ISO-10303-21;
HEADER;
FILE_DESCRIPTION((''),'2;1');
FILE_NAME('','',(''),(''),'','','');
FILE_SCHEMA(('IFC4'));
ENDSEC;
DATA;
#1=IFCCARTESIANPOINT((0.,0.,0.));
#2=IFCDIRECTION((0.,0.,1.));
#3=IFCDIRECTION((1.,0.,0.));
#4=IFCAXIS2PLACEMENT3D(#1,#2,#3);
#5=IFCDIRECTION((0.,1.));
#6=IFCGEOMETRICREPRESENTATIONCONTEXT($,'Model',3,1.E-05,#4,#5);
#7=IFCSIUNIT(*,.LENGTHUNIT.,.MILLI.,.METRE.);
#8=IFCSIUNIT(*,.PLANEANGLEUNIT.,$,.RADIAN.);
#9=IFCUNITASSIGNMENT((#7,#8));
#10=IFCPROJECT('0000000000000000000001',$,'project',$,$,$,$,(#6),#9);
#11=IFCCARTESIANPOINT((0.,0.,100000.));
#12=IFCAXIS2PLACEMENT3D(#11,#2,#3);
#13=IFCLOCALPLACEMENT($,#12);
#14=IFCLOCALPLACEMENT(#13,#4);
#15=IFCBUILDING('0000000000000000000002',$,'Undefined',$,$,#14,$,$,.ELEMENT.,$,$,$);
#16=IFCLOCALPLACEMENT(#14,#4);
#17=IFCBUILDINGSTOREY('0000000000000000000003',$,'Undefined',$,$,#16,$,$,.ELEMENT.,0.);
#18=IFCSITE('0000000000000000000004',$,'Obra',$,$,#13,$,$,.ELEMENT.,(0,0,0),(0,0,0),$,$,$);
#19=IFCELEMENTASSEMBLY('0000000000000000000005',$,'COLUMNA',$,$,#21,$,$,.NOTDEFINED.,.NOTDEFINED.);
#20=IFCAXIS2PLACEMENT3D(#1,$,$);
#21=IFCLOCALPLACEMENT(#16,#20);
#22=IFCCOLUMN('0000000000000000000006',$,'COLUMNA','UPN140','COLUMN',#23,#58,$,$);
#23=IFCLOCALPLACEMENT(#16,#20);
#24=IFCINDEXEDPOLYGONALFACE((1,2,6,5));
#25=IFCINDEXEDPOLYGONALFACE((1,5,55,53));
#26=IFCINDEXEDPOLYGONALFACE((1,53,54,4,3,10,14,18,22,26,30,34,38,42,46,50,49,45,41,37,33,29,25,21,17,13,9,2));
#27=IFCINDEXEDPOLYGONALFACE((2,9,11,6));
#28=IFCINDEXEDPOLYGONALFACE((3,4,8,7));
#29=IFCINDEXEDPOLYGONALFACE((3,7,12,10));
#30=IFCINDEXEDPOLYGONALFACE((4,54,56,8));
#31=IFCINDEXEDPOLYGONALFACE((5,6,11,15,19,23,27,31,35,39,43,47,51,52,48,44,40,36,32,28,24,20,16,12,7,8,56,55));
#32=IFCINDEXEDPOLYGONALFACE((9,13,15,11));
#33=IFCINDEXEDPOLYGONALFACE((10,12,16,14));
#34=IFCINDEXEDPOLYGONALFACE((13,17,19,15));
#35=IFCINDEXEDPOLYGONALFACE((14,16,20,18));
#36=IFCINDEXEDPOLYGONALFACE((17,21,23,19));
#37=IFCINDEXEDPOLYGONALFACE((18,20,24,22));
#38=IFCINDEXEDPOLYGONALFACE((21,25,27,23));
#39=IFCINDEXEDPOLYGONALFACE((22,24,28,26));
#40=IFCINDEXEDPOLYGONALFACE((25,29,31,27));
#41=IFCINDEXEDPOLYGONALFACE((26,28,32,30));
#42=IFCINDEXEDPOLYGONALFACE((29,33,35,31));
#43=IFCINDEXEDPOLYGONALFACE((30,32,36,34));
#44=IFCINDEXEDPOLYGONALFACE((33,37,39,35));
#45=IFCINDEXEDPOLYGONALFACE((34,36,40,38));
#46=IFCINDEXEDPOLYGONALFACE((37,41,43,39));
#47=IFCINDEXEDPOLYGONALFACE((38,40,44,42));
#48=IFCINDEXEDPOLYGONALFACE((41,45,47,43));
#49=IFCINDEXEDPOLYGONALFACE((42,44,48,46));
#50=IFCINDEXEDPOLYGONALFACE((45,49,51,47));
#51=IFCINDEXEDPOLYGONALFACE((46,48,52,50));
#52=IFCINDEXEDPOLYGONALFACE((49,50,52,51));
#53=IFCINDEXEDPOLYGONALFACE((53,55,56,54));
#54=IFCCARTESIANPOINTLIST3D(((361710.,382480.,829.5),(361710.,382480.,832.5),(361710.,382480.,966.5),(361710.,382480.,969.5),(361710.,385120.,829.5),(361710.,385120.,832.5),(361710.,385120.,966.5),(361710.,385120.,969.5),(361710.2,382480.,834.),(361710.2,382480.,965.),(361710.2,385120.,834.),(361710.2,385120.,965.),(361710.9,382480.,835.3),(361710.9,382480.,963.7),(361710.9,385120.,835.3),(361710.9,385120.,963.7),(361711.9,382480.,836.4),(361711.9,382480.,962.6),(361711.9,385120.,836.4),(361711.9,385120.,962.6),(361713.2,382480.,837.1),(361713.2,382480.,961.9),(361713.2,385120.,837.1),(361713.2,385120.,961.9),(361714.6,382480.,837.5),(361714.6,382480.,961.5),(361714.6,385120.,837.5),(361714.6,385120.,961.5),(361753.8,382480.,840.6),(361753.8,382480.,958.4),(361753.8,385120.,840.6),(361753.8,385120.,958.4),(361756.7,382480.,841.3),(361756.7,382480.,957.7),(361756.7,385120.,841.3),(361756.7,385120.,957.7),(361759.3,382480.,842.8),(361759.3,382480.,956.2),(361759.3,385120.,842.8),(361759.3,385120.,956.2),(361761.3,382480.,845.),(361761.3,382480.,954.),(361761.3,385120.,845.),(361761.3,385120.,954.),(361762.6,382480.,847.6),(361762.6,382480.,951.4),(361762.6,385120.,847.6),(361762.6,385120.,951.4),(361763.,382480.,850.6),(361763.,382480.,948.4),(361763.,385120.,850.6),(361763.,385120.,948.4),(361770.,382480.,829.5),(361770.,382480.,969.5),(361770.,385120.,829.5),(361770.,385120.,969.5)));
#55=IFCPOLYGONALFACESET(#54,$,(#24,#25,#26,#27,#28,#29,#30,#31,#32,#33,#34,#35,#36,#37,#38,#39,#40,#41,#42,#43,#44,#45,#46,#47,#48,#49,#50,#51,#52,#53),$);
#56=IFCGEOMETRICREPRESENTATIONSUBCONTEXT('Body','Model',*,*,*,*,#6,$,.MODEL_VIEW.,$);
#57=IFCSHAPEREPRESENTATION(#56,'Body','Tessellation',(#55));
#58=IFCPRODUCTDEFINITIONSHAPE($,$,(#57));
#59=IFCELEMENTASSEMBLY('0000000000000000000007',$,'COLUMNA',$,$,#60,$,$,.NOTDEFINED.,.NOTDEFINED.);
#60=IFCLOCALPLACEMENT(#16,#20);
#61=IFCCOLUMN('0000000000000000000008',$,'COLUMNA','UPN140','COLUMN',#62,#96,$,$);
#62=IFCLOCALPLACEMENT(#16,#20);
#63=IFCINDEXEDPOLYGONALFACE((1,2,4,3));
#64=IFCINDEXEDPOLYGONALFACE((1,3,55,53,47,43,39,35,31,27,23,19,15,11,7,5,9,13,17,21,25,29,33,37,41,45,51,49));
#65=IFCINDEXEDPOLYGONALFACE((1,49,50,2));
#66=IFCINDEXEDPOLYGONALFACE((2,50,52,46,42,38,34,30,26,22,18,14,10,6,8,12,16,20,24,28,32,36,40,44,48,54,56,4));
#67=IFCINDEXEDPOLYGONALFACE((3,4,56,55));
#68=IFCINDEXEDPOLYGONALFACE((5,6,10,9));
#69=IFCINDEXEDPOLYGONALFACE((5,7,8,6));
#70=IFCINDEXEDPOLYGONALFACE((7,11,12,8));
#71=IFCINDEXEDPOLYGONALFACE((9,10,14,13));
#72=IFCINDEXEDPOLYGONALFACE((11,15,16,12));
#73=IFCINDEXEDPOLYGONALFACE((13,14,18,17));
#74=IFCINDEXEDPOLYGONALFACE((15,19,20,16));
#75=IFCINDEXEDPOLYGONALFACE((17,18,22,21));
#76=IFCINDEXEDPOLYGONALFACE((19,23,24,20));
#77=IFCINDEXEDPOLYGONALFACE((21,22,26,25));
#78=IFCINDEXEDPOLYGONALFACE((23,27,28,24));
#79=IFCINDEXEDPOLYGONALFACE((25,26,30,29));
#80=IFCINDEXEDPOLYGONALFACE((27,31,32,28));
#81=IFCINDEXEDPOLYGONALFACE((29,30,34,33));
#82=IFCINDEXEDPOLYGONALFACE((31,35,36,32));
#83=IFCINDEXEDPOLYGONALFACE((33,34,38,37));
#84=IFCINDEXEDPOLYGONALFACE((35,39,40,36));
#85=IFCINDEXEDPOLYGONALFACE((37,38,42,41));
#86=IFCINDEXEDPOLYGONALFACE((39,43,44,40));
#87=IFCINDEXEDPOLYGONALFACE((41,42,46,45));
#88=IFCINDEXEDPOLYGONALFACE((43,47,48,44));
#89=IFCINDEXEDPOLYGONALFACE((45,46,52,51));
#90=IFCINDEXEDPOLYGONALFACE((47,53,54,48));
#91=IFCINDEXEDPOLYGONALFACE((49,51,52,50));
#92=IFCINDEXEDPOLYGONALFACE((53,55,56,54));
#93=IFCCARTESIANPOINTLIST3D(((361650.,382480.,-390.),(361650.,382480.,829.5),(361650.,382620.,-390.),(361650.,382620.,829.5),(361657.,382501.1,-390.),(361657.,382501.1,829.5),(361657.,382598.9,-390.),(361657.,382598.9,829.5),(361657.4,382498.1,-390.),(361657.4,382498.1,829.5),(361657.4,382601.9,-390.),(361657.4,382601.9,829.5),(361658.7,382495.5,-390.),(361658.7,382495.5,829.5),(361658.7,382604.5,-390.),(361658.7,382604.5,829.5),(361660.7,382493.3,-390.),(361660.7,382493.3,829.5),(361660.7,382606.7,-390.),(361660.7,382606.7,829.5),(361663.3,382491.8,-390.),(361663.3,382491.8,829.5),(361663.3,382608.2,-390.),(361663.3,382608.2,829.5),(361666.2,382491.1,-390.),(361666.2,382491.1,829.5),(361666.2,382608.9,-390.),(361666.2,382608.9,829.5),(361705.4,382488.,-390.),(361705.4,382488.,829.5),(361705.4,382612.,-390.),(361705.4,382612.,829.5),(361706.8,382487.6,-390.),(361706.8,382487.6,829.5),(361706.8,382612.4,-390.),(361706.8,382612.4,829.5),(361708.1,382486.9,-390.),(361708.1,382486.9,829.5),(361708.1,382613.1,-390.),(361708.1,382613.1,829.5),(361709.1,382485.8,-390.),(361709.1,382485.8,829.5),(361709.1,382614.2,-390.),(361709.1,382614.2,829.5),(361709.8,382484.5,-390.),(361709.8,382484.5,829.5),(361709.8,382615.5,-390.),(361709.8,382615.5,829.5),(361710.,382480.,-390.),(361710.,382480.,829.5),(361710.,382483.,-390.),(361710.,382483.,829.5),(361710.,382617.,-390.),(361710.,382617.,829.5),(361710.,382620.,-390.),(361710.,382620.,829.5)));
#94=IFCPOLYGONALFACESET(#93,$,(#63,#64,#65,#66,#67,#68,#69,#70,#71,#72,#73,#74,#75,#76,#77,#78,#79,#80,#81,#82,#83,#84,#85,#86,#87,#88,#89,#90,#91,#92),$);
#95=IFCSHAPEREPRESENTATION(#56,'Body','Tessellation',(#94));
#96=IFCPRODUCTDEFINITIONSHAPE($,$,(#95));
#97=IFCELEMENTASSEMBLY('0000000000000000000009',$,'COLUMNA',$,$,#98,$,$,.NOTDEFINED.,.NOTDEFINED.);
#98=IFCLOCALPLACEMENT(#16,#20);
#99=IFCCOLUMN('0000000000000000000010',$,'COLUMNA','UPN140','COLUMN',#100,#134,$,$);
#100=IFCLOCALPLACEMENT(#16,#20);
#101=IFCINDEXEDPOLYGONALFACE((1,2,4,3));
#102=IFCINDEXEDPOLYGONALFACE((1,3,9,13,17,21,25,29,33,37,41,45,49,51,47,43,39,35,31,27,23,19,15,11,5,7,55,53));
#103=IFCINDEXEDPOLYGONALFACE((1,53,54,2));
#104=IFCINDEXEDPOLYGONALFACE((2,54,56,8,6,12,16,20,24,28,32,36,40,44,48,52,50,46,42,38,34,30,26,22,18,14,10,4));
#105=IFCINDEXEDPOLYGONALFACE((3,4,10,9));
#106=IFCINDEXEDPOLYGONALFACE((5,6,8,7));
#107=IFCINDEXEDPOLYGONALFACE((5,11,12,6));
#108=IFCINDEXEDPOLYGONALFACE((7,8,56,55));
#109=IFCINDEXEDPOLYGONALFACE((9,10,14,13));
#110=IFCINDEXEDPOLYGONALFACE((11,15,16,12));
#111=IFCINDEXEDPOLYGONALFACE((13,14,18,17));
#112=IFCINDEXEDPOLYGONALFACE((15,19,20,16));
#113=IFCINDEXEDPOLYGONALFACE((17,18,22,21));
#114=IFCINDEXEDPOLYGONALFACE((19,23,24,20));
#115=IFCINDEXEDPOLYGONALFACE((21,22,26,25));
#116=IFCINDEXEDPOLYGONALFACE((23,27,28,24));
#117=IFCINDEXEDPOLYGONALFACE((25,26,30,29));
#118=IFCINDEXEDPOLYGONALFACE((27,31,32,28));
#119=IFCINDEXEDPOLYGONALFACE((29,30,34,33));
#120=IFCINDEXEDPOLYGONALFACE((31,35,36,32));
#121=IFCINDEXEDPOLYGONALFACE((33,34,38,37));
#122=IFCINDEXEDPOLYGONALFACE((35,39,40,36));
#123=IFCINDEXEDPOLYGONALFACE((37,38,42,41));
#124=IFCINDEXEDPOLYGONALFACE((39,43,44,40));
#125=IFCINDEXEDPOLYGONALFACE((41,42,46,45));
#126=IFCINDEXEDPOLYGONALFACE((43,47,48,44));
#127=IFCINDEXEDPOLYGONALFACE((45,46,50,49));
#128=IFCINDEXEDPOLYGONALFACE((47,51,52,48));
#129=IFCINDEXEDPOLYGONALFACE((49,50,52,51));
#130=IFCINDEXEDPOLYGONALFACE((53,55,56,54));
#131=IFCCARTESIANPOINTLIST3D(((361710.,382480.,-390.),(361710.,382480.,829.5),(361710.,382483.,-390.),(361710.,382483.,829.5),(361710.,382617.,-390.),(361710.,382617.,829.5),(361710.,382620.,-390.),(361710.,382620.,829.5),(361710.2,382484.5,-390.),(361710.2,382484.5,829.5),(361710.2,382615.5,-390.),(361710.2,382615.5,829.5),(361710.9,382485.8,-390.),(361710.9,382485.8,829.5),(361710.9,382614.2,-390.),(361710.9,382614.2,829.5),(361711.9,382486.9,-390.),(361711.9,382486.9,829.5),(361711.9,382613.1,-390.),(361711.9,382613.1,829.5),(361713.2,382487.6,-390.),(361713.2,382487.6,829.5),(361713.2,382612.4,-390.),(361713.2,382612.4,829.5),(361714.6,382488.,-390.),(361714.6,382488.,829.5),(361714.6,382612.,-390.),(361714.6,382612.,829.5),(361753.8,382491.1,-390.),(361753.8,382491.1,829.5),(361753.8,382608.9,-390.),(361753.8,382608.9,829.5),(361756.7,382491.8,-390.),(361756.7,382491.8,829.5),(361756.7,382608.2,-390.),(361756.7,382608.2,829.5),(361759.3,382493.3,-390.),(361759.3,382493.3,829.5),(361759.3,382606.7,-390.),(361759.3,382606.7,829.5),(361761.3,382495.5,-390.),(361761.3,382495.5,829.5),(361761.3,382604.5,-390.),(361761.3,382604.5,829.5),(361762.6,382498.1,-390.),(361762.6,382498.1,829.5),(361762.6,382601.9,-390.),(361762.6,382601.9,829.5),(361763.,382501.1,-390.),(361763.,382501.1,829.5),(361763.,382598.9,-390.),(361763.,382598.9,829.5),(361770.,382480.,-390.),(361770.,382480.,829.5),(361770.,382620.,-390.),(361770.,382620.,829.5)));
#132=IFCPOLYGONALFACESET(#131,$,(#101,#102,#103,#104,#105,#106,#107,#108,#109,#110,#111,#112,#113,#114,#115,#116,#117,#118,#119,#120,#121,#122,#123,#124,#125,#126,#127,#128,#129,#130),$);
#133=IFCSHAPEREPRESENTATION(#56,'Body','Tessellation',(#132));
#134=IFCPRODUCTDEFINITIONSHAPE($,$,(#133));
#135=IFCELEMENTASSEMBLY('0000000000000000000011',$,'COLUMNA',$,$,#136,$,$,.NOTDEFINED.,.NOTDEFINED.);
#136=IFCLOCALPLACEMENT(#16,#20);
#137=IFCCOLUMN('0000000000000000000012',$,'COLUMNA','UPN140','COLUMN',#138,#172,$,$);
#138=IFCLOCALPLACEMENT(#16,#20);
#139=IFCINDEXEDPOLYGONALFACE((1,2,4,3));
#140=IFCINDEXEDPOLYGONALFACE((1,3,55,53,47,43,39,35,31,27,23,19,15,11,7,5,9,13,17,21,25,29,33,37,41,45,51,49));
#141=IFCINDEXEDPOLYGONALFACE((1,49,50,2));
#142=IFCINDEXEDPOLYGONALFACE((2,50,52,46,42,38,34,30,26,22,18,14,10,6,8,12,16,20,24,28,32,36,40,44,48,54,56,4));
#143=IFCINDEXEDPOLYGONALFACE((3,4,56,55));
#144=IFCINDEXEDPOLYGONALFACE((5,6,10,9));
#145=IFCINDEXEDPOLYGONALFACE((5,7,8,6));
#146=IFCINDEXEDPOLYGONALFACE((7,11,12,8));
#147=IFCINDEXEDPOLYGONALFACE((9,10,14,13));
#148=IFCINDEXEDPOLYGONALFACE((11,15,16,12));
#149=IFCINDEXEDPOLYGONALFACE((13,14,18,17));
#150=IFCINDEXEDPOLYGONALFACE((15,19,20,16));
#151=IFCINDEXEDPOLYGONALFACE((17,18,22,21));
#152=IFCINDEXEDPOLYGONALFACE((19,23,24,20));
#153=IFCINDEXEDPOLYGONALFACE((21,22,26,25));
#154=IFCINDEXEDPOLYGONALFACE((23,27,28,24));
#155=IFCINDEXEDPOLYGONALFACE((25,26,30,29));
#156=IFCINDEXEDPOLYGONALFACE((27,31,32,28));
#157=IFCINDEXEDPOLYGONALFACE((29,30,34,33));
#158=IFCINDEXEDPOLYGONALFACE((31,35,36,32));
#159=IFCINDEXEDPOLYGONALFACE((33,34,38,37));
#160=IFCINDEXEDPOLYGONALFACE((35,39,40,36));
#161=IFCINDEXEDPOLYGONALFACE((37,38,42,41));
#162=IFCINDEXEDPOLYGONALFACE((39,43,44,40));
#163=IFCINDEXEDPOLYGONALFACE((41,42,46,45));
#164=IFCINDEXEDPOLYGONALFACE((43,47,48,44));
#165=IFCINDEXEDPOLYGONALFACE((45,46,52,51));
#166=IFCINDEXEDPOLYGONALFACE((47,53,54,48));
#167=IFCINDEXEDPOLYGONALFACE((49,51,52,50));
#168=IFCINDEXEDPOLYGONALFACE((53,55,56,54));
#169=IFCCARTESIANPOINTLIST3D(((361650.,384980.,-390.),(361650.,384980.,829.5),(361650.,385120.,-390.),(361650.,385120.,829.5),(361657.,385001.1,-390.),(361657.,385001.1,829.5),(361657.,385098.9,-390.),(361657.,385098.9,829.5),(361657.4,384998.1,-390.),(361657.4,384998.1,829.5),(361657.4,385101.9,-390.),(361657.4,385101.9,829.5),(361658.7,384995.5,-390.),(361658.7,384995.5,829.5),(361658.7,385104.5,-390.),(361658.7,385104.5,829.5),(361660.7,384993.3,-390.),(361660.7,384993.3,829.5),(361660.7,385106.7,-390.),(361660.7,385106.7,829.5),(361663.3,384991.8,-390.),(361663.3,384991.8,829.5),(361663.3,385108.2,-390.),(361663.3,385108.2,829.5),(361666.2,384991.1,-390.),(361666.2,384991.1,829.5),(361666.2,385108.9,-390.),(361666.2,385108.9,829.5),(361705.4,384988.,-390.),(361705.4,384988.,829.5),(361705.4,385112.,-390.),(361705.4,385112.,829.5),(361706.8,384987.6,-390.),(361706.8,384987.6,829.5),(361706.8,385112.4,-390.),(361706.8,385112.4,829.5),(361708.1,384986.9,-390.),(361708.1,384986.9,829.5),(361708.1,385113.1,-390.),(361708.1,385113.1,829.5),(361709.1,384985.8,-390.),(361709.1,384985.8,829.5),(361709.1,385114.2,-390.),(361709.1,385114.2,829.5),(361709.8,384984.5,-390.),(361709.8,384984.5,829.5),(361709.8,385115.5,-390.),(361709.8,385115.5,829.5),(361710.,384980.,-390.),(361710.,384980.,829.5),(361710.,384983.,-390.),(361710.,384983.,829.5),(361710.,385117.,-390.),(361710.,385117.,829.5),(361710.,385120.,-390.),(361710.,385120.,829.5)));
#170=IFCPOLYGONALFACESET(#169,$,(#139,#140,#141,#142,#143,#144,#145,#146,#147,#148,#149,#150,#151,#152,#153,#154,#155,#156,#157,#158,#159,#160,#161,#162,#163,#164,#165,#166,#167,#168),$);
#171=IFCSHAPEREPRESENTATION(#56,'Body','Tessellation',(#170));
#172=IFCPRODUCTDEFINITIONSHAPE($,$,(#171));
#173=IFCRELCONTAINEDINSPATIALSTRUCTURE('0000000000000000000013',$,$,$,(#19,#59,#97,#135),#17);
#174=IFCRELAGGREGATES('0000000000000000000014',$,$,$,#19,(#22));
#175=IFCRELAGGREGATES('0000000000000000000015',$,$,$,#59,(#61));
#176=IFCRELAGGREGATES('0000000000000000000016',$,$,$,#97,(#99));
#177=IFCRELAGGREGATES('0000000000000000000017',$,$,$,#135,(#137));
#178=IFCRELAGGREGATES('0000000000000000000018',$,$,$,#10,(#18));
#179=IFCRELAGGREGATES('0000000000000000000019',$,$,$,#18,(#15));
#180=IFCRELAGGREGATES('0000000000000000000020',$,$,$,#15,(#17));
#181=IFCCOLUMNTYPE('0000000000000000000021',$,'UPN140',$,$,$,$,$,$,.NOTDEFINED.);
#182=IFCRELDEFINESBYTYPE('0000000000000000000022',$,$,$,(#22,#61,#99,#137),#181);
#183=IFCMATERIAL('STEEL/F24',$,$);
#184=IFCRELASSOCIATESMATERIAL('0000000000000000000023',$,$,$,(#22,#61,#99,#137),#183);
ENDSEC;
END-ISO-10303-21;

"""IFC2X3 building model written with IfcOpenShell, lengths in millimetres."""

from ifc_helpers import new_model, si_unit, direction, frame, origin_with_axes, origin_2d_with_axis, place, context, subcontext, project, spatial, u_section, extrude, material, type_object, element, aggregate, save


model = new_model("IFC2X3")

# Units and contexts
model_context = context("Model", 3, precision=1e-05, world=origin_with_axes(), true_north=direction((0.0, 1.0)))
body_context = subcontext(model_context, "Body", "Model", "MODEL_VIEW")
ifc_project = project(units=[si_unit("LENGTHUNIT", "METRE", prefix="MILLI"), si_unit("PLANEANGLEUNIT", "RADIAN")], contexts=[model_context])

# Site, building, storey
site_placement = place(None, frame((0.0, 0.0, 100000.0), z_axis=(0.0, 0.0, 1.0), x_axis=(1.0, 0.0, 0.0)))
site = spatial("IfcSite", under=ifc_project, at=site_placement, Name="Obra", CompositionType="ELEMENT", RefLatitude=(0, 0, 0), RefLongitude=(0, 0, 0))
building_placement = place(site_placement, origin_with_axes())
building = spatial("IfcBuilding", under=site, at=building_placement, Name="Undefined", CompositionType="ELEMENT")
storey_placement = place(building_placement, origin_with_axes())
storey = spatial("IfcBuildingStorey", under=building, at=storey_placement, Name="Undefined", CompositionType="ELEMENT", Elevation=0.0)

# Element assemblies, columns
ifc_material_1 = material(Name="STEEL/F24")
column_type_1 = type_object("IfcColumnType", Name="UPN140", PredefinedType="NOTDEFINED")
assembly_1_placement = place(storey_placement, origin_with_axes())
assembly_1 = element("IfcElementAssembly", 1, at=assembly_1_placement, inside=storey, Name="COLUMNA", AssemblyPlace="NOTDEFINED", PredefinedType="NOTDEFINED")
column_1_placement = place(assembly_1_placement, frame((361740.0, 385120.0, 899.5), z_axis=(0.0, -1.0, 0.0), x_axis=(0.0, 0.0, 1.0)))
column_1 = element("IfcColumn", 2, at=column_1_placement, type_object=column_type_1, material=ifc_material_1, Name="COLUMNA", Description="UPN140", ObjectType="COLUMN", context=body_context, shape_type="SweptSolid", body=[
    extrude(u_section(Depth=140.0, FlangeWidth=60.0, WebThickness=7.0, FlangeThickness=10.0, FilletRadius=10.0, EdgeRadius=5.0, FlangeSlope=0.07983, at=origin_2d_with_axis()), frame((0.0, 0.0, 2640.0), z_axis=(0.0, 0.0, -1.0), x_axis=(0.0, 1.0, 0.0)), (0.0, 0.0, 1.0), 2640.0),
])
aggregate(assembly_1, [column_1])
assembly_2_placement = place(storey_placement, origin_with_axes())
assembly_2 = element("IfcElementAssembly", 3, at=assembly_2_placement, inside=storey, Name="COLUMNA", AssemblyPlace="NOTDEFINED", PredefinedType="NOTDEFINED")
column_2_placement = place(assembly_2_placement, frame((361680.0, 382550.0, -390.0), z_axis=(0.0, 0.0, 1.0), x_axis=(0.0, -1.0, 0.0)))
column_2 = element("IfcColumn", 4, at=column_2_placement, type_object=column_type_1, material=ifc_material_1, Name="COLUMNA", Description="UPN140", ObjectType="COLUMN", context=body_context, shape_type="SweptSolid", body=[
    extrude(u_section(Depth=140.0, FlangeWidth=60.0, WebThickness=7.0, FlangeThickness=10.0, FilletRadius=10.0, EdgeRadius=5.0, FlangeSlope=0.07983, at=origin_2d_with_axis()), frame((0.0, 0.0, 1219.5), z_axis=(0.0, 0.0, -1.0), x_axis=(0.0, 1.0, 0.0)), (0.0, 0.0, 1.0), 1219.5),
])
aggregate(assembly_2, [column_2])
assembly_3_placement = place(storey_placement, origin_with_axes())
assembly_3 = element("IfcElementAssembly", 5, at=assembly_3_placement, inside=storey, Name="COLUMNA", AssemblyPlace="NOTDEFINED", PredefinedType="NOTDEFINED")
column_3_placement = place(assembly_3_placement, frame((361740.0, 382550.0, -390.0), z_axis=(0.0, 0.0, 1.0), x_axis=(0.0, 1.0, 0.0)))
column_3 = element("IfcColumn", 6, at=column_3_placement, type_object=column_type_1, material=ifc_material_1, Name="COLUMNA", Description="UPN140", ObjectType="COLUMN", context=body_context, shape_type="SweptSolid", body=[
    extrude(u_section(Depth=140.0, FlangeWidth=60.0, WebThickness=7.0, FlangeThickness=10.0, FilletRadius=10.0, EdgeRadius=5.0, FlangeSlope=0.07983, at=origin_2d_with_axis()), frame((0.0, 0.0, 1219.5), z_axis=(0.0, 0.0, -1.0), x_axis=(0.0, 1.0, 0.0)), (0.0, 0.0, 1.0), 1219.5),
])
aggregate(assembly_3, [column_3])
assembly_4_placement = place(storey_placement, origin_with_axes())
assembly_4 = element("IfcElementAssembly", 7, at=assembly_4_placement, inside=storey, Name="COLUMNA", AssemblyPlace="NOTDEFINED", PredefinedType="NOTDEFINED")
column_4_placement = place(assembly_4_placement, frame((361680.0, 385050.0, -390.0), z_axis=(0.0, 0.0, 1.0), x_axis=(0.0, -1.0, 0.0)))
column_4 = element("IfcColumn", 8, at=column_4_placement, type_object=column_type_1, material=ifc_material_1, Name="COLUMNA", Description="UPN140", ObjectType="COLUMN", context=body_context, shape_type="SweptSolid", body=[
    extrude(u_section(Depth=140.0, FlangeWidth=60.0, WebThickness=7.0, FlangeThickness=10.0, FilletRadius=10.0, EdgeRadius=5.0, FlangeSlope=0.07983, at=origin_2d_with_axis()), frame((0.0, 0.0, 1219.5), z_axis=(0.0, 0.0, -1.0), x_axis=(0.0, 1.0, 0.0)), (0.0, 0.0, 1.0), 1219.5),
])
aggregate(assembly_4, [column_4])

save(model, "model.ifc")
